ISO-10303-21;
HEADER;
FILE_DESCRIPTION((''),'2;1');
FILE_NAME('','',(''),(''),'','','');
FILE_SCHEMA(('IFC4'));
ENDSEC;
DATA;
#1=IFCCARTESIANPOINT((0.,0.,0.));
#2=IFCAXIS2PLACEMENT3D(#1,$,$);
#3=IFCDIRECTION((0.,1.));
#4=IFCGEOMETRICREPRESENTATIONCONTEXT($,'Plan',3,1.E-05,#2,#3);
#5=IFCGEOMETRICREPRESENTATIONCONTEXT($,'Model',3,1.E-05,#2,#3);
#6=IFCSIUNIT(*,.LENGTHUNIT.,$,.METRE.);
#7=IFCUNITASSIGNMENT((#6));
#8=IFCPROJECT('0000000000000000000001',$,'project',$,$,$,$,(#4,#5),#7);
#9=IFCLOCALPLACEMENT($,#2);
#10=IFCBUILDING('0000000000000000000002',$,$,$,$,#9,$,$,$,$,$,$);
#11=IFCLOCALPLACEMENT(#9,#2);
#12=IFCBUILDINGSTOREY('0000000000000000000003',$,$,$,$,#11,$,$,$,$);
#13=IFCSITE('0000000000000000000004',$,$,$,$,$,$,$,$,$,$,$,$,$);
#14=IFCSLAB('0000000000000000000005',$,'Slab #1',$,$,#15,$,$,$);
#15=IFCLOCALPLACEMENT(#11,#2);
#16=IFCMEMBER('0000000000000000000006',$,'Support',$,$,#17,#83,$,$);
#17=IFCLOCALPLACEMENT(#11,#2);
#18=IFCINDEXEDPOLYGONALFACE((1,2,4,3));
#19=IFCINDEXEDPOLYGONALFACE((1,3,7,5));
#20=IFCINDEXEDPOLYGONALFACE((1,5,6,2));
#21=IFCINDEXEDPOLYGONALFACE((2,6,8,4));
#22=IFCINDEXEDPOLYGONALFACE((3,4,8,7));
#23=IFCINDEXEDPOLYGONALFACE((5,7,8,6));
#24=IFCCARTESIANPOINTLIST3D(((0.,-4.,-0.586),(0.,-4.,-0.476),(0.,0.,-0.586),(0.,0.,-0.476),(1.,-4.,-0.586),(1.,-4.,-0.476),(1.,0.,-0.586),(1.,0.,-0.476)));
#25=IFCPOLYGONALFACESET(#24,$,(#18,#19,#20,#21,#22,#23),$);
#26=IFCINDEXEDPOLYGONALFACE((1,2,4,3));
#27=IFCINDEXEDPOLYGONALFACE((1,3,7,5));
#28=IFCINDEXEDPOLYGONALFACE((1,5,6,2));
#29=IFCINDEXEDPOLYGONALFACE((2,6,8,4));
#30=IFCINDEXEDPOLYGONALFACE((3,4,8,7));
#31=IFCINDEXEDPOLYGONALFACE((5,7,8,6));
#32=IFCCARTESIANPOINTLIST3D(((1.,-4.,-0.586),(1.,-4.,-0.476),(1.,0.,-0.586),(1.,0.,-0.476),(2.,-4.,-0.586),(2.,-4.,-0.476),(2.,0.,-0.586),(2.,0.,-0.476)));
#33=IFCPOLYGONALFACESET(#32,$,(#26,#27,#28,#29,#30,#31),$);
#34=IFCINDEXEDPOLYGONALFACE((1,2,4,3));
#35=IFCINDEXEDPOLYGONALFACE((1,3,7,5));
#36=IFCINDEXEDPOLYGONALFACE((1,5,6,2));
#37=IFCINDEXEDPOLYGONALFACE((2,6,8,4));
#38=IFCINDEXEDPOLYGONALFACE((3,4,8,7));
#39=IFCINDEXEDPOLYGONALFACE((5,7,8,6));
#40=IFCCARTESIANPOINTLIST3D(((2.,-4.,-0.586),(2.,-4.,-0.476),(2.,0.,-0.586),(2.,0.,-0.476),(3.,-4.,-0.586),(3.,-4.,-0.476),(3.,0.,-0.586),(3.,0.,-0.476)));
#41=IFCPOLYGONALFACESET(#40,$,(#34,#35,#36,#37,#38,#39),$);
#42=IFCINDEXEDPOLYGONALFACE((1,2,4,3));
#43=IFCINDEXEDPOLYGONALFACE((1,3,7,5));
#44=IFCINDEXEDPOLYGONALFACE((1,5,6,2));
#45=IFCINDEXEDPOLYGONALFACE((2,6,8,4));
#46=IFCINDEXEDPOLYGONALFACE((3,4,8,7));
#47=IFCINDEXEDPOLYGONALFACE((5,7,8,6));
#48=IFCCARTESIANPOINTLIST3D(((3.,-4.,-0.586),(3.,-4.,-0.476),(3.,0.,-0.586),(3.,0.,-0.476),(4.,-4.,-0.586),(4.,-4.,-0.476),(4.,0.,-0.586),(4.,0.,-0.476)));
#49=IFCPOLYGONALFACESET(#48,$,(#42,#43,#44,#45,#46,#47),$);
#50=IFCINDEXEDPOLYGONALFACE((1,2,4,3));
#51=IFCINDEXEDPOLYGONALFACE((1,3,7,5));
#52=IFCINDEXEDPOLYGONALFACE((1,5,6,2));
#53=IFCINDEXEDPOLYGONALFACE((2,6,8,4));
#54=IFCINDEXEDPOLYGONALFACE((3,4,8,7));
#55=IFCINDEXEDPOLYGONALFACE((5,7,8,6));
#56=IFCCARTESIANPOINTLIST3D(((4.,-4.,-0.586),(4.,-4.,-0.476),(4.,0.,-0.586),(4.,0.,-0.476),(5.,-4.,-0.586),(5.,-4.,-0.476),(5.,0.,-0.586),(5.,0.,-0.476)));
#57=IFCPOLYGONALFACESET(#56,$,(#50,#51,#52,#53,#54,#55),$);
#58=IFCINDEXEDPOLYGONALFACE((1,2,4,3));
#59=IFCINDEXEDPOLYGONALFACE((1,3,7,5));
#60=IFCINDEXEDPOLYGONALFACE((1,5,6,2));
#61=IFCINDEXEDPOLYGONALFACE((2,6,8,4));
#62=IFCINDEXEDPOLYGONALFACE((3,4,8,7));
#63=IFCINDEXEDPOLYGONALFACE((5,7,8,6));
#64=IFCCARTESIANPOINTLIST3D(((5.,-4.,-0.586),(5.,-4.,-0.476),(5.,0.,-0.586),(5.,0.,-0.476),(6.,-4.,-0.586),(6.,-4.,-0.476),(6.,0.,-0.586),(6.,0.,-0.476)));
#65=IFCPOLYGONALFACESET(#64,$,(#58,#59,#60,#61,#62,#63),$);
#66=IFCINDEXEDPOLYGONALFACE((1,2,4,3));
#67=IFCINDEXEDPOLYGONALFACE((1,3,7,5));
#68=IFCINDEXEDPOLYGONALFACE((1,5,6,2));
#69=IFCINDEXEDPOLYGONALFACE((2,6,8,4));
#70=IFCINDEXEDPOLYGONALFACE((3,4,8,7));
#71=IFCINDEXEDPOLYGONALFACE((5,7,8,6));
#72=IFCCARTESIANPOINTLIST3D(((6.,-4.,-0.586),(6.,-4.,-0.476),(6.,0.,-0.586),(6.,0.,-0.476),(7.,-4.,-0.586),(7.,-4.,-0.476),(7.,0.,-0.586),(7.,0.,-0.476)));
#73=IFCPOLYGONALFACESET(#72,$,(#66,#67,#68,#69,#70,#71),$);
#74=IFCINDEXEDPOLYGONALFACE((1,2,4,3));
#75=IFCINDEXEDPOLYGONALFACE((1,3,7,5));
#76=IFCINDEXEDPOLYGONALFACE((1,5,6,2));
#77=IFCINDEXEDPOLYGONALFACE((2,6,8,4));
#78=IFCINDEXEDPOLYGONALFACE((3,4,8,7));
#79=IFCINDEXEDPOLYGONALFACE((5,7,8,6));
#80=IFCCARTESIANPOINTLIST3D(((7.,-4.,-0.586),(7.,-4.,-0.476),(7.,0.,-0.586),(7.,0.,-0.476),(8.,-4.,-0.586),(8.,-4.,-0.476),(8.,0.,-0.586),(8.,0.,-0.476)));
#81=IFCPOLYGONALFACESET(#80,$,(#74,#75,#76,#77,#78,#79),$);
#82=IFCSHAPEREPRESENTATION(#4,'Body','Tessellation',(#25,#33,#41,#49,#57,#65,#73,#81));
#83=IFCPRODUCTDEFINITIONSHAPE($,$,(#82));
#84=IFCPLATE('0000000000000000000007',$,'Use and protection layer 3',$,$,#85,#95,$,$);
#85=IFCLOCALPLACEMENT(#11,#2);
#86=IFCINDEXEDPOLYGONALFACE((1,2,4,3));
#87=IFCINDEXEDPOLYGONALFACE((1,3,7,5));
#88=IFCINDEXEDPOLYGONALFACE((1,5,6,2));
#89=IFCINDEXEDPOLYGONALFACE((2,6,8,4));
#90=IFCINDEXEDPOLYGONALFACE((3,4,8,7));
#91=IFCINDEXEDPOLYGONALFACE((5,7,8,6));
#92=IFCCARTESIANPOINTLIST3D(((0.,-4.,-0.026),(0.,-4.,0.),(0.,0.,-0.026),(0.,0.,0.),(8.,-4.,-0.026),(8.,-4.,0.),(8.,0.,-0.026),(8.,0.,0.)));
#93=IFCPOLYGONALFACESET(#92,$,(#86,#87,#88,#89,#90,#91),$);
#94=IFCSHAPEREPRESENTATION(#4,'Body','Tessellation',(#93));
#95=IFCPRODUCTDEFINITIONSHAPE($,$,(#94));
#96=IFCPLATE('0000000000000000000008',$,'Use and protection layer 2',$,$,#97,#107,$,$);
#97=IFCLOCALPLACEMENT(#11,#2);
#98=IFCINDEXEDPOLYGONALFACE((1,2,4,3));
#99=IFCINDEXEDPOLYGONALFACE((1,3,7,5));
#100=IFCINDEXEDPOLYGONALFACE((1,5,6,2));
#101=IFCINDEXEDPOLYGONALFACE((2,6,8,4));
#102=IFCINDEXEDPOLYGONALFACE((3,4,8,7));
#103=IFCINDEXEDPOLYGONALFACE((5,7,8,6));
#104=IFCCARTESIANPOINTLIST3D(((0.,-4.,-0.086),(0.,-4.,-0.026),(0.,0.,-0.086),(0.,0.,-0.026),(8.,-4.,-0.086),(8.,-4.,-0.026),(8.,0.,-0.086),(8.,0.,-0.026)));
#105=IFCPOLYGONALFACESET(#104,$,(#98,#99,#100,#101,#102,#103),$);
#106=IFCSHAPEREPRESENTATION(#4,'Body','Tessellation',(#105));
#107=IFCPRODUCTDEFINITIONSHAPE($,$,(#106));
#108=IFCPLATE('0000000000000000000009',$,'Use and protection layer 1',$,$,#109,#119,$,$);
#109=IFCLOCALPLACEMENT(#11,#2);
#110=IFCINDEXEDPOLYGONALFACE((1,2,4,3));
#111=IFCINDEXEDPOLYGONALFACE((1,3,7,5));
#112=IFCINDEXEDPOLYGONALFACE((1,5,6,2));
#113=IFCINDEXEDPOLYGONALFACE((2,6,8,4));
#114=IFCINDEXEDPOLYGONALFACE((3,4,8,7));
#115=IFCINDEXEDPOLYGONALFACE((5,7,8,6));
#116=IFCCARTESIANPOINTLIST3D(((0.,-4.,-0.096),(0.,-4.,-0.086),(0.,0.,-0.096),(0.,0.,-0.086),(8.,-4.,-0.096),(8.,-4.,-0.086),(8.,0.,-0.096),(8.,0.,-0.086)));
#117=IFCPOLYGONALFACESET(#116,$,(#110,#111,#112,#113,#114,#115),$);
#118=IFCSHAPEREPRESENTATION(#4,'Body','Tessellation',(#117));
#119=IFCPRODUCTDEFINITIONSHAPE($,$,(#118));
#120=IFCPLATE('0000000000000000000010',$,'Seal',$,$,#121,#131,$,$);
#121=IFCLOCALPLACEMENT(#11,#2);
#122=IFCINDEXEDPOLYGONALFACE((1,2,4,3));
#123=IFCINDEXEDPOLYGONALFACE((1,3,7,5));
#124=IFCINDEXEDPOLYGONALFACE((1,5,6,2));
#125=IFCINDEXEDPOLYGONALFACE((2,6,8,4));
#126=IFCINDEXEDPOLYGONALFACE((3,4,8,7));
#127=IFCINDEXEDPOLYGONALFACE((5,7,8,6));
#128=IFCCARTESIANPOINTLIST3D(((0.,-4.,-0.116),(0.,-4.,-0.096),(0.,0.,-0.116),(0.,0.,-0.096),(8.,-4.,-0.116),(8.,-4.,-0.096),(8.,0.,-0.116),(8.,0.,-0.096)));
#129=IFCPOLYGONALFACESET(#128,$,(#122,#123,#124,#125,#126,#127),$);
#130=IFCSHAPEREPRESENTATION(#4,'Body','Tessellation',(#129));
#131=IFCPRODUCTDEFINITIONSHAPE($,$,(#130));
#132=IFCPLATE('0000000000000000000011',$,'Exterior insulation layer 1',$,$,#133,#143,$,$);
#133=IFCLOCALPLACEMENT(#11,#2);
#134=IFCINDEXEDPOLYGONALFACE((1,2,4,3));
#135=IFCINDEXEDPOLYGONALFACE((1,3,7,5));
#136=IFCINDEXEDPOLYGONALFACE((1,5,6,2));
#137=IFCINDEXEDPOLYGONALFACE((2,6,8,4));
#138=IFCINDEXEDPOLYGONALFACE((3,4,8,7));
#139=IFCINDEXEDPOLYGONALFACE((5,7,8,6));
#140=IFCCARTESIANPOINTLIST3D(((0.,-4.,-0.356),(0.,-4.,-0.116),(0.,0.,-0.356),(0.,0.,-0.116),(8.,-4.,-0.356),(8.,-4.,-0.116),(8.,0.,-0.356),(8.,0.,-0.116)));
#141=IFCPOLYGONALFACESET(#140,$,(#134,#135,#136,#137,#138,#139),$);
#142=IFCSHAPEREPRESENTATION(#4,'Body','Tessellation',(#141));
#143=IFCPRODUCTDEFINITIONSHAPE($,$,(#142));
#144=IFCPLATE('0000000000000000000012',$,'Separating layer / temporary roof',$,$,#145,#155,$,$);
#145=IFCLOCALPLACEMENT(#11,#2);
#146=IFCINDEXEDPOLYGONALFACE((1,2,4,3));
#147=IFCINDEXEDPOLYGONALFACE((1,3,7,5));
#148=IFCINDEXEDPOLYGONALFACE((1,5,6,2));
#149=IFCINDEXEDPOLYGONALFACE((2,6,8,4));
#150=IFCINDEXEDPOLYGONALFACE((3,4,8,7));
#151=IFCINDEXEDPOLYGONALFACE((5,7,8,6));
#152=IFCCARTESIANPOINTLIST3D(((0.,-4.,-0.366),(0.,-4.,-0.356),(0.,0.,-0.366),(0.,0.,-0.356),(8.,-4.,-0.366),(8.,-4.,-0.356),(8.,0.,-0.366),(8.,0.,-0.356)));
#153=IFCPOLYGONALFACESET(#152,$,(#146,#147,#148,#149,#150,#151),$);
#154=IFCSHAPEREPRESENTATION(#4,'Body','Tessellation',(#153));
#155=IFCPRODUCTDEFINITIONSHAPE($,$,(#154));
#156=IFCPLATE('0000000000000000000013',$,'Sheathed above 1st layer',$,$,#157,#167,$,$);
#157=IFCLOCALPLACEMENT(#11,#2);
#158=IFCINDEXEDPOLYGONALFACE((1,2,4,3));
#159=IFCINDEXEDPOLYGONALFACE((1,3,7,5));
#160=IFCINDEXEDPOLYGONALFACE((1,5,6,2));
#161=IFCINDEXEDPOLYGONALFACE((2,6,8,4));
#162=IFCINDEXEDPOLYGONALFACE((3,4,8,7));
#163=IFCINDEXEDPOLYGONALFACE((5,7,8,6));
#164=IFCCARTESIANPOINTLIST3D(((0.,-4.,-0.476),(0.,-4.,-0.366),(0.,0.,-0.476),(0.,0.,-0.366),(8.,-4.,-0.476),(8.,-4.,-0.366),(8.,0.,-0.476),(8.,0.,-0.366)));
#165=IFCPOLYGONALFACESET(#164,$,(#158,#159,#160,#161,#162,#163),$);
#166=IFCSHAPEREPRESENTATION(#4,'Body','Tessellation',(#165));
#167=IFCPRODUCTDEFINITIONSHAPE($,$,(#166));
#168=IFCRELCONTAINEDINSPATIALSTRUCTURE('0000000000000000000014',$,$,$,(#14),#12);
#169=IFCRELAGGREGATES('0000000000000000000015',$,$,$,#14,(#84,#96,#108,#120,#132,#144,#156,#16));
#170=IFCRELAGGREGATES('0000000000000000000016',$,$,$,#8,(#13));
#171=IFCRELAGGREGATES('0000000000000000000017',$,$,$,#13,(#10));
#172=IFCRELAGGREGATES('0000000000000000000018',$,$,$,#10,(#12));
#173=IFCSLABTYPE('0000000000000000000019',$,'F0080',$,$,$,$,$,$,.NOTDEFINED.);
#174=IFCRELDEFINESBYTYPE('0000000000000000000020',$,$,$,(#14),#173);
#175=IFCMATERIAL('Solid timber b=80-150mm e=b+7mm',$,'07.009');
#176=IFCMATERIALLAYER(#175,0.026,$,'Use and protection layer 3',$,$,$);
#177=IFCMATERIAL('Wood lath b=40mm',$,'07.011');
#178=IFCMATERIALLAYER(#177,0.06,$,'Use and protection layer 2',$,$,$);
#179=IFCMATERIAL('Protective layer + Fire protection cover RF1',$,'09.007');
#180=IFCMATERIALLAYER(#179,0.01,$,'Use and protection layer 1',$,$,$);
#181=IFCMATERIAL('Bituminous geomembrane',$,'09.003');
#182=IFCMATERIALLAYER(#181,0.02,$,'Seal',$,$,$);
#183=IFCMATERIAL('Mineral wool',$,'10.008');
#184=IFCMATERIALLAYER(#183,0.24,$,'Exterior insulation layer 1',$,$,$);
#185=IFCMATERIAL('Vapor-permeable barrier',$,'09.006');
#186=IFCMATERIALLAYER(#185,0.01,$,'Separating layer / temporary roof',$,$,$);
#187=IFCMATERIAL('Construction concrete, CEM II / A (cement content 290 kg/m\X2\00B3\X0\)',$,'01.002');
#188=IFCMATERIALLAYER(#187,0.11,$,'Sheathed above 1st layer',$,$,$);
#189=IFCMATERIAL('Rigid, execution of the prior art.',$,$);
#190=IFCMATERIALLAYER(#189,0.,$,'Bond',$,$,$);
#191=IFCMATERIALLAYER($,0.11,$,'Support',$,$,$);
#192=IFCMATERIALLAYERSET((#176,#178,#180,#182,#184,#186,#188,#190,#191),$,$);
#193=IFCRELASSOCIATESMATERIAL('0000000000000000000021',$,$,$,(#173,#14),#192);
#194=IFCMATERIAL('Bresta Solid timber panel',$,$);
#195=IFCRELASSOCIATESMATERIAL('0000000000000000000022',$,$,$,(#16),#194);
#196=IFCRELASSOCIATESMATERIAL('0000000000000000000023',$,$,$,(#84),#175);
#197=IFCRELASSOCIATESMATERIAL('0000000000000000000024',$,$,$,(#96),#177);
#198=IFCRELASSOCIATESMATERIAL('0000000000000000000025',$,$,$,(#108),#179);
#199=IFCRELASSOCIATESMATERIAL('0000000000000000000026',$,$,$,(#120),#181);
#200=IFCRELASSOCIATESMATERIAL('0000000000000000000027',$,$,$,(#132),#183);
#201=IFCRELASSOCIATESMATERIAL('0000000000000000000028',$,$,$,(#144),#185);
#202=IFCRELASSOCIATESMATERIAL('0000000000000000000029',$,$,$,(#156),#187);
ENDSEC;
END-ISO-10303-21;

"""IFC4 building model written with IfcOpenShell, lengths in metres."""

from ifc_helpers import new_model, si_unit, direction, frame, frame_2d, origin, origin_with_axes, place, context, project, spatial, rectangle, extrude, material, layer, layer_set, type_object, element, aggregate, save


model = new_model("IFC4")

# Units and contexts
plan_context = context("Plan", 3, precision=1e-05, world=origin(), true_north=direction((0.0, 1.0)))
model_context = context("Model", 3, precision=1e-05, world=origin(), true_north=direction((0.0, 1.0)))
ifc_project = project(units=[si_unit("LENGTHUNIT", "METRE")], contexts=[plan_context, model_context])

# Site, building, storey
site = spatial("IfcSite", under=ifc_project)
building_placement = place(None, origin())
building = spatial("IfcBuilding", under=site, at=building_placement)
storey_placement = place(building_placement, origin())
storey = spatial("IfcBuildingStorey", under=building, at=storey_placement)

# Slab, member, plates
ifc_material_1 = material(Name="Solid timber b=80-150mm e=b+7mm", Category="07.009")
ifc_layer_1 = layer(ifc_material_1, 0.026, Name="Use and protection layer 3")
ifc_material_2 = material(Name="Wood lath b=40mm", Category="07.011")
ifc_layer_2 = layer(ifc_material_2, 0.06, Name="Use and protection layer 2")
ifc_material_3 = material(Name="Protective layer + Fire protection cover RF1", Category="09.007")
ifc_layer_3 = layer(ifc_material_3, 0.01, Name="Use and protection layer 1")
ifc_material_4 = material(Name="Bituminous geomembrane", Category="09.003")
ifc_layer_4 = layer(ifc_material_4, 0.02, Name="Seal")
ifc_material_5 = material(Name="Mineral wool", Category="10.008")
ifc_layer_5 = layer(ifc_material_5, 0.24, Name="Exterior insulation layer 1")
ifc_material_6 = material(Name="Vapor-permeable barrier", Category="09.006")
ifc_layer_6 = layer(ifc_material_6, 0.01, Name="Separating layer / temporary roof")
ifc_material_7 = material(Name="Construction concrete, CEM II / A (cement content 290 kg/m³)", Category="01.002")
ifc_layer_7 = layer(ifc_material_7, 0.11, Name="Sheathed above 1st layer")
ifc_material_8 = material(Name="Rigid, execution of the prior art.")
ifc_layer_8 = layer(ifc_material_8, 0.0, Name="Bond")
ifc_layer_9 = layer(None, 0.11, Name="Support")
ifc_layer_set = layer_set([ifc_layer_1, ifc_layer_2, ifc_layer_3, ifc_layer_4, ifc_layer_5, ifc_layer_6, ifc_layer_7, ifc_layer_8, ifc_layer_9])
slab_type = type_object("IfcSlabType", Name="F0080", PredefinedType="NOTDEFINED", material=ifc_layer_set)
slab_placement = place(None, frame((0.0, 0.0, 0.0), z_axis=(0.0, 0.0, -1.0), x_axis=(1.0, 0.0, 0.0)))
slab = element("IfcSlab", 1, at=slab_placement, inside=storey, type_object=slab_type, material=ifc_layer_set, Name="Slab #1")
ifc_material_9 = material(Name="Bresta Solid timber panel")
member_placement = place(slab_placement, origin())
member = element("IfcMember", 2, at=member_placement, material=ifc_material_9, Name="Support", context=plan_context, shape_type="SweptSolid", body=[
    extrude(rectangle(XDim=1.0, YDim=0.11, at=frame_2d((0.5, 0.055), x_axis=(1.0, 0.0))), frame((0.0, 4.0, 0.476), z_axis=(0.0, -1.0, 0.0), x_axis=(1.0, 0.0, 0.0)), (0.0, 0.0, 1.0), 4.0),
    extrude(rectangle(XDim=1.0, YDim=0.11, at=frame_2d((0.5, 0.055), x_axis=(1.0, 0.0))), frame((1.0, 4.0, 0.476), z_axis=(0.0, -1.0, 0.0), x_axis=(1.0, 0.0, 0.0)), (0.0, 0.0, 1.0), 4.0),
    extrude(rectangle(XDim=1.0, YDim=0.11, at=frame_2d((0.5, 0.055), x_axis=(1.0, 0.0))), frame((2.0, 4.0, 0.476), z_axis=(0.0, -1.0, 0.0), x_axis=(1.0, 0.0, 0.0)), (0.0, 0.0, 1.0), 4.0),
    extrude(rectangle(XDim=1.0, YDim=0.11, at=frame_2d((0.5, 0.055), x_axis=(1.0, 0.0))), frame((3.0, 4.0, 0.476), z_axis=(0.0, -1.0, 0.0), x_axis=(1.0, 0.0, 0.0)), (0.0, 0.0, 1.0), 4.0),
    extrude(rectangle(XDim=1.0, YDim=0.11, at=frame_2d((0.5, 0.055), x_axis=(1.0, 0.0))), frame((4.0, 4.0, 0.476), z_axis=(0.0, -1.0, 0.0), x_axis=(1.0, 0.0, 0.0)), (0.0, 0.0, 1.0), 4.0),
    extrude(rectangle(XDim=1.0, YDim=0.11, at=frame_2d((0.5, 0.055), x_axis=(1.0, 0.0))), frame((5.0, 4.0, 0.476), z_axis=(0.0, -1.0, 0.0), x_axis=(1.0, 0.0, 0.0)), (0.0, 0.0, 1.0), 4.0),
    extrude(rectangle(XDim=1.0, YDim=0.11, at=frame_2d((0.5, 0.055), x_axis=(1.0, 0.0))), frame((6.0, 4.0, 0.476), z_axis=(0.0, -1.0, 0.0), x_axis=(1.0, 0.0, 0.0)), (0.0, 0.0, 1.0), 4.0),
    extrude(rectangle(XDim=1.0, YDim=0.11, at=frame_2d((0.5, 0.055), x_axis=(1.0, 0.0))), frame((7.0, 4.0, 0.476), z_axis=(0.0, -1.0, 0.0), x_axis=(1.0, 0.0, 0.0)), (0.0, 0.0, 1.0), 4.0),
])
plate_1_placement = place(slab_placement, origin())
plate_1 = element("IfcPlate", 3, at=plate_1_placement, material=ifc_material_1, Name="Use and protection layer 3", context=plan_context, shape_type="SweptSolid", body=[
    extrude(rectangle(XDim=8.0, YDim=4.0, at=frame_2d((4.0, 2.0), x_axis=(1.0, 0.0))), origin_with_axes(), (0.0, 0.0, 1.0), 0.026),
])
plate_2_placement = place(slab_placement, origin())
plate_2 = element("IfcPlate", 4, at=plate_2_placement, material=ifc_material_2, Name="Use and protection layer 2", context=plan_context, shape_type="SweptSolid", body=[
    extrude(rectangle(XDim=8.0, YDim=4.0, at=frame_2d((4.0, 2.0), x_axis=(1.0, 0.0))), frame((0.0, 0.0, 0.026), z_axis=(0.0, 0.0, 1.0), x_axis=(1.0, 0.0, 0.0)), (0.0, 0.0, 1.0), 0.06),
])
plate_3_placement = place(slab_placement, origin())
plate_3 = element("IfcPlate", 5, at=plate_3_placement, material=ifc_material_3, Name="Use and protection layer 1", context=plan_context, shape_type="SweptSolid", body=[
    extrude(rectangle(XDim=8.0, YDim=4.0, at=frame_2d((4.0, 2.0), x_axis=(1.0, 0.0))), frame((0.0, 0.0, 0.086), z_axis=(0.0, 0.0, 1.0), x_axis=(1.0, 0.0, 0.0)), (0.0, 0.0, 1.0), 0.01),
])
plate_4_placement = place(slab_placement, origin())
plate_4 = element("IfcPlate", 6, at=plate_4_placement, material=ifc_material_4, Name="Seal", context=plan_context, shape_type="SweptSolid", body=[
    extrude(rectangle(XDim=8.0, YDim=4.0, at=frame_2d((4.0, 2.0), x_axis=(1.0, 0.0))), frame((0.0, 0.0, 0.096), z_axis=(0.0, 0.0, 1.0), x_axis=(1.0, 0.0, 0.0)), (0.0, 0.0, 1.0), 0.02),
])
plate_5_placement = place(slab_placement, origin())
plate_5 = element("IfcPlate", 7, at=plate_5_placement, material=ifc_material_5, Name="Exterior insulation layer 1", context=plan_context, shape_type="SweptSolid", body=[
    extrude(rectangle(XDim=8.0, YDim=4.0, at=frame_2d((4.0, 2.0), x_axis=(1.0, 0.0))), frame((0.0, 0.0, 0.116), z_axis=(0.0, 0.0, 1.0), x_axis=(1.0, 0.0, 0.0)), (0.0, 0.0, 1.0), 0.24),
])
plate_6_placement = place(slab_placement, origin())
plate_6 = element("IfcPlate", 8, at=plate_6_placement, material=ifc_material_6, Name="Separating layer / temporary roof", context=plan_context, shape_type="SweptSolid", body=[
    extrude(rectangle(XDim=8.0, YDim=4.0, at=frame_2d((4.0, 2.0), x_axis=(1.0, 0.0))), frame((0.0, 0.0, 0.356), z_axis=(0.0, 0.0, 1.0), x_axis=(1.0, 0.0, 0.0)), (0.0, 0.0, 1.0), 0.01),
])
plate_7_placement = place(slab_placement, origin())
plate_7 = element("IfcPlate", 9, at=plate_7_placement, material=ifc_material_7, Name="Sheathed above 1st layer", context=plan_context, shape_type="SweptSolid", body=[
    extrude(rectangle(XDim=8.0, YDim=4.0, at=frame_2d((4.0, 2.0), x_axis=(1.0, 0.0))), frame((0.0, 0.0, 0.366), z_axis=(0.0, 0.0, 1.0), x_axis=(1.0, 0.0, 0.0)), (0.0, 0.0, 1.0), 0.11),
])
aggregate(slab, [plate_1, plate_2, plate_3, plate_4, plate_5, plate_6, plate_7, member])

save(model, "model.ifc")
